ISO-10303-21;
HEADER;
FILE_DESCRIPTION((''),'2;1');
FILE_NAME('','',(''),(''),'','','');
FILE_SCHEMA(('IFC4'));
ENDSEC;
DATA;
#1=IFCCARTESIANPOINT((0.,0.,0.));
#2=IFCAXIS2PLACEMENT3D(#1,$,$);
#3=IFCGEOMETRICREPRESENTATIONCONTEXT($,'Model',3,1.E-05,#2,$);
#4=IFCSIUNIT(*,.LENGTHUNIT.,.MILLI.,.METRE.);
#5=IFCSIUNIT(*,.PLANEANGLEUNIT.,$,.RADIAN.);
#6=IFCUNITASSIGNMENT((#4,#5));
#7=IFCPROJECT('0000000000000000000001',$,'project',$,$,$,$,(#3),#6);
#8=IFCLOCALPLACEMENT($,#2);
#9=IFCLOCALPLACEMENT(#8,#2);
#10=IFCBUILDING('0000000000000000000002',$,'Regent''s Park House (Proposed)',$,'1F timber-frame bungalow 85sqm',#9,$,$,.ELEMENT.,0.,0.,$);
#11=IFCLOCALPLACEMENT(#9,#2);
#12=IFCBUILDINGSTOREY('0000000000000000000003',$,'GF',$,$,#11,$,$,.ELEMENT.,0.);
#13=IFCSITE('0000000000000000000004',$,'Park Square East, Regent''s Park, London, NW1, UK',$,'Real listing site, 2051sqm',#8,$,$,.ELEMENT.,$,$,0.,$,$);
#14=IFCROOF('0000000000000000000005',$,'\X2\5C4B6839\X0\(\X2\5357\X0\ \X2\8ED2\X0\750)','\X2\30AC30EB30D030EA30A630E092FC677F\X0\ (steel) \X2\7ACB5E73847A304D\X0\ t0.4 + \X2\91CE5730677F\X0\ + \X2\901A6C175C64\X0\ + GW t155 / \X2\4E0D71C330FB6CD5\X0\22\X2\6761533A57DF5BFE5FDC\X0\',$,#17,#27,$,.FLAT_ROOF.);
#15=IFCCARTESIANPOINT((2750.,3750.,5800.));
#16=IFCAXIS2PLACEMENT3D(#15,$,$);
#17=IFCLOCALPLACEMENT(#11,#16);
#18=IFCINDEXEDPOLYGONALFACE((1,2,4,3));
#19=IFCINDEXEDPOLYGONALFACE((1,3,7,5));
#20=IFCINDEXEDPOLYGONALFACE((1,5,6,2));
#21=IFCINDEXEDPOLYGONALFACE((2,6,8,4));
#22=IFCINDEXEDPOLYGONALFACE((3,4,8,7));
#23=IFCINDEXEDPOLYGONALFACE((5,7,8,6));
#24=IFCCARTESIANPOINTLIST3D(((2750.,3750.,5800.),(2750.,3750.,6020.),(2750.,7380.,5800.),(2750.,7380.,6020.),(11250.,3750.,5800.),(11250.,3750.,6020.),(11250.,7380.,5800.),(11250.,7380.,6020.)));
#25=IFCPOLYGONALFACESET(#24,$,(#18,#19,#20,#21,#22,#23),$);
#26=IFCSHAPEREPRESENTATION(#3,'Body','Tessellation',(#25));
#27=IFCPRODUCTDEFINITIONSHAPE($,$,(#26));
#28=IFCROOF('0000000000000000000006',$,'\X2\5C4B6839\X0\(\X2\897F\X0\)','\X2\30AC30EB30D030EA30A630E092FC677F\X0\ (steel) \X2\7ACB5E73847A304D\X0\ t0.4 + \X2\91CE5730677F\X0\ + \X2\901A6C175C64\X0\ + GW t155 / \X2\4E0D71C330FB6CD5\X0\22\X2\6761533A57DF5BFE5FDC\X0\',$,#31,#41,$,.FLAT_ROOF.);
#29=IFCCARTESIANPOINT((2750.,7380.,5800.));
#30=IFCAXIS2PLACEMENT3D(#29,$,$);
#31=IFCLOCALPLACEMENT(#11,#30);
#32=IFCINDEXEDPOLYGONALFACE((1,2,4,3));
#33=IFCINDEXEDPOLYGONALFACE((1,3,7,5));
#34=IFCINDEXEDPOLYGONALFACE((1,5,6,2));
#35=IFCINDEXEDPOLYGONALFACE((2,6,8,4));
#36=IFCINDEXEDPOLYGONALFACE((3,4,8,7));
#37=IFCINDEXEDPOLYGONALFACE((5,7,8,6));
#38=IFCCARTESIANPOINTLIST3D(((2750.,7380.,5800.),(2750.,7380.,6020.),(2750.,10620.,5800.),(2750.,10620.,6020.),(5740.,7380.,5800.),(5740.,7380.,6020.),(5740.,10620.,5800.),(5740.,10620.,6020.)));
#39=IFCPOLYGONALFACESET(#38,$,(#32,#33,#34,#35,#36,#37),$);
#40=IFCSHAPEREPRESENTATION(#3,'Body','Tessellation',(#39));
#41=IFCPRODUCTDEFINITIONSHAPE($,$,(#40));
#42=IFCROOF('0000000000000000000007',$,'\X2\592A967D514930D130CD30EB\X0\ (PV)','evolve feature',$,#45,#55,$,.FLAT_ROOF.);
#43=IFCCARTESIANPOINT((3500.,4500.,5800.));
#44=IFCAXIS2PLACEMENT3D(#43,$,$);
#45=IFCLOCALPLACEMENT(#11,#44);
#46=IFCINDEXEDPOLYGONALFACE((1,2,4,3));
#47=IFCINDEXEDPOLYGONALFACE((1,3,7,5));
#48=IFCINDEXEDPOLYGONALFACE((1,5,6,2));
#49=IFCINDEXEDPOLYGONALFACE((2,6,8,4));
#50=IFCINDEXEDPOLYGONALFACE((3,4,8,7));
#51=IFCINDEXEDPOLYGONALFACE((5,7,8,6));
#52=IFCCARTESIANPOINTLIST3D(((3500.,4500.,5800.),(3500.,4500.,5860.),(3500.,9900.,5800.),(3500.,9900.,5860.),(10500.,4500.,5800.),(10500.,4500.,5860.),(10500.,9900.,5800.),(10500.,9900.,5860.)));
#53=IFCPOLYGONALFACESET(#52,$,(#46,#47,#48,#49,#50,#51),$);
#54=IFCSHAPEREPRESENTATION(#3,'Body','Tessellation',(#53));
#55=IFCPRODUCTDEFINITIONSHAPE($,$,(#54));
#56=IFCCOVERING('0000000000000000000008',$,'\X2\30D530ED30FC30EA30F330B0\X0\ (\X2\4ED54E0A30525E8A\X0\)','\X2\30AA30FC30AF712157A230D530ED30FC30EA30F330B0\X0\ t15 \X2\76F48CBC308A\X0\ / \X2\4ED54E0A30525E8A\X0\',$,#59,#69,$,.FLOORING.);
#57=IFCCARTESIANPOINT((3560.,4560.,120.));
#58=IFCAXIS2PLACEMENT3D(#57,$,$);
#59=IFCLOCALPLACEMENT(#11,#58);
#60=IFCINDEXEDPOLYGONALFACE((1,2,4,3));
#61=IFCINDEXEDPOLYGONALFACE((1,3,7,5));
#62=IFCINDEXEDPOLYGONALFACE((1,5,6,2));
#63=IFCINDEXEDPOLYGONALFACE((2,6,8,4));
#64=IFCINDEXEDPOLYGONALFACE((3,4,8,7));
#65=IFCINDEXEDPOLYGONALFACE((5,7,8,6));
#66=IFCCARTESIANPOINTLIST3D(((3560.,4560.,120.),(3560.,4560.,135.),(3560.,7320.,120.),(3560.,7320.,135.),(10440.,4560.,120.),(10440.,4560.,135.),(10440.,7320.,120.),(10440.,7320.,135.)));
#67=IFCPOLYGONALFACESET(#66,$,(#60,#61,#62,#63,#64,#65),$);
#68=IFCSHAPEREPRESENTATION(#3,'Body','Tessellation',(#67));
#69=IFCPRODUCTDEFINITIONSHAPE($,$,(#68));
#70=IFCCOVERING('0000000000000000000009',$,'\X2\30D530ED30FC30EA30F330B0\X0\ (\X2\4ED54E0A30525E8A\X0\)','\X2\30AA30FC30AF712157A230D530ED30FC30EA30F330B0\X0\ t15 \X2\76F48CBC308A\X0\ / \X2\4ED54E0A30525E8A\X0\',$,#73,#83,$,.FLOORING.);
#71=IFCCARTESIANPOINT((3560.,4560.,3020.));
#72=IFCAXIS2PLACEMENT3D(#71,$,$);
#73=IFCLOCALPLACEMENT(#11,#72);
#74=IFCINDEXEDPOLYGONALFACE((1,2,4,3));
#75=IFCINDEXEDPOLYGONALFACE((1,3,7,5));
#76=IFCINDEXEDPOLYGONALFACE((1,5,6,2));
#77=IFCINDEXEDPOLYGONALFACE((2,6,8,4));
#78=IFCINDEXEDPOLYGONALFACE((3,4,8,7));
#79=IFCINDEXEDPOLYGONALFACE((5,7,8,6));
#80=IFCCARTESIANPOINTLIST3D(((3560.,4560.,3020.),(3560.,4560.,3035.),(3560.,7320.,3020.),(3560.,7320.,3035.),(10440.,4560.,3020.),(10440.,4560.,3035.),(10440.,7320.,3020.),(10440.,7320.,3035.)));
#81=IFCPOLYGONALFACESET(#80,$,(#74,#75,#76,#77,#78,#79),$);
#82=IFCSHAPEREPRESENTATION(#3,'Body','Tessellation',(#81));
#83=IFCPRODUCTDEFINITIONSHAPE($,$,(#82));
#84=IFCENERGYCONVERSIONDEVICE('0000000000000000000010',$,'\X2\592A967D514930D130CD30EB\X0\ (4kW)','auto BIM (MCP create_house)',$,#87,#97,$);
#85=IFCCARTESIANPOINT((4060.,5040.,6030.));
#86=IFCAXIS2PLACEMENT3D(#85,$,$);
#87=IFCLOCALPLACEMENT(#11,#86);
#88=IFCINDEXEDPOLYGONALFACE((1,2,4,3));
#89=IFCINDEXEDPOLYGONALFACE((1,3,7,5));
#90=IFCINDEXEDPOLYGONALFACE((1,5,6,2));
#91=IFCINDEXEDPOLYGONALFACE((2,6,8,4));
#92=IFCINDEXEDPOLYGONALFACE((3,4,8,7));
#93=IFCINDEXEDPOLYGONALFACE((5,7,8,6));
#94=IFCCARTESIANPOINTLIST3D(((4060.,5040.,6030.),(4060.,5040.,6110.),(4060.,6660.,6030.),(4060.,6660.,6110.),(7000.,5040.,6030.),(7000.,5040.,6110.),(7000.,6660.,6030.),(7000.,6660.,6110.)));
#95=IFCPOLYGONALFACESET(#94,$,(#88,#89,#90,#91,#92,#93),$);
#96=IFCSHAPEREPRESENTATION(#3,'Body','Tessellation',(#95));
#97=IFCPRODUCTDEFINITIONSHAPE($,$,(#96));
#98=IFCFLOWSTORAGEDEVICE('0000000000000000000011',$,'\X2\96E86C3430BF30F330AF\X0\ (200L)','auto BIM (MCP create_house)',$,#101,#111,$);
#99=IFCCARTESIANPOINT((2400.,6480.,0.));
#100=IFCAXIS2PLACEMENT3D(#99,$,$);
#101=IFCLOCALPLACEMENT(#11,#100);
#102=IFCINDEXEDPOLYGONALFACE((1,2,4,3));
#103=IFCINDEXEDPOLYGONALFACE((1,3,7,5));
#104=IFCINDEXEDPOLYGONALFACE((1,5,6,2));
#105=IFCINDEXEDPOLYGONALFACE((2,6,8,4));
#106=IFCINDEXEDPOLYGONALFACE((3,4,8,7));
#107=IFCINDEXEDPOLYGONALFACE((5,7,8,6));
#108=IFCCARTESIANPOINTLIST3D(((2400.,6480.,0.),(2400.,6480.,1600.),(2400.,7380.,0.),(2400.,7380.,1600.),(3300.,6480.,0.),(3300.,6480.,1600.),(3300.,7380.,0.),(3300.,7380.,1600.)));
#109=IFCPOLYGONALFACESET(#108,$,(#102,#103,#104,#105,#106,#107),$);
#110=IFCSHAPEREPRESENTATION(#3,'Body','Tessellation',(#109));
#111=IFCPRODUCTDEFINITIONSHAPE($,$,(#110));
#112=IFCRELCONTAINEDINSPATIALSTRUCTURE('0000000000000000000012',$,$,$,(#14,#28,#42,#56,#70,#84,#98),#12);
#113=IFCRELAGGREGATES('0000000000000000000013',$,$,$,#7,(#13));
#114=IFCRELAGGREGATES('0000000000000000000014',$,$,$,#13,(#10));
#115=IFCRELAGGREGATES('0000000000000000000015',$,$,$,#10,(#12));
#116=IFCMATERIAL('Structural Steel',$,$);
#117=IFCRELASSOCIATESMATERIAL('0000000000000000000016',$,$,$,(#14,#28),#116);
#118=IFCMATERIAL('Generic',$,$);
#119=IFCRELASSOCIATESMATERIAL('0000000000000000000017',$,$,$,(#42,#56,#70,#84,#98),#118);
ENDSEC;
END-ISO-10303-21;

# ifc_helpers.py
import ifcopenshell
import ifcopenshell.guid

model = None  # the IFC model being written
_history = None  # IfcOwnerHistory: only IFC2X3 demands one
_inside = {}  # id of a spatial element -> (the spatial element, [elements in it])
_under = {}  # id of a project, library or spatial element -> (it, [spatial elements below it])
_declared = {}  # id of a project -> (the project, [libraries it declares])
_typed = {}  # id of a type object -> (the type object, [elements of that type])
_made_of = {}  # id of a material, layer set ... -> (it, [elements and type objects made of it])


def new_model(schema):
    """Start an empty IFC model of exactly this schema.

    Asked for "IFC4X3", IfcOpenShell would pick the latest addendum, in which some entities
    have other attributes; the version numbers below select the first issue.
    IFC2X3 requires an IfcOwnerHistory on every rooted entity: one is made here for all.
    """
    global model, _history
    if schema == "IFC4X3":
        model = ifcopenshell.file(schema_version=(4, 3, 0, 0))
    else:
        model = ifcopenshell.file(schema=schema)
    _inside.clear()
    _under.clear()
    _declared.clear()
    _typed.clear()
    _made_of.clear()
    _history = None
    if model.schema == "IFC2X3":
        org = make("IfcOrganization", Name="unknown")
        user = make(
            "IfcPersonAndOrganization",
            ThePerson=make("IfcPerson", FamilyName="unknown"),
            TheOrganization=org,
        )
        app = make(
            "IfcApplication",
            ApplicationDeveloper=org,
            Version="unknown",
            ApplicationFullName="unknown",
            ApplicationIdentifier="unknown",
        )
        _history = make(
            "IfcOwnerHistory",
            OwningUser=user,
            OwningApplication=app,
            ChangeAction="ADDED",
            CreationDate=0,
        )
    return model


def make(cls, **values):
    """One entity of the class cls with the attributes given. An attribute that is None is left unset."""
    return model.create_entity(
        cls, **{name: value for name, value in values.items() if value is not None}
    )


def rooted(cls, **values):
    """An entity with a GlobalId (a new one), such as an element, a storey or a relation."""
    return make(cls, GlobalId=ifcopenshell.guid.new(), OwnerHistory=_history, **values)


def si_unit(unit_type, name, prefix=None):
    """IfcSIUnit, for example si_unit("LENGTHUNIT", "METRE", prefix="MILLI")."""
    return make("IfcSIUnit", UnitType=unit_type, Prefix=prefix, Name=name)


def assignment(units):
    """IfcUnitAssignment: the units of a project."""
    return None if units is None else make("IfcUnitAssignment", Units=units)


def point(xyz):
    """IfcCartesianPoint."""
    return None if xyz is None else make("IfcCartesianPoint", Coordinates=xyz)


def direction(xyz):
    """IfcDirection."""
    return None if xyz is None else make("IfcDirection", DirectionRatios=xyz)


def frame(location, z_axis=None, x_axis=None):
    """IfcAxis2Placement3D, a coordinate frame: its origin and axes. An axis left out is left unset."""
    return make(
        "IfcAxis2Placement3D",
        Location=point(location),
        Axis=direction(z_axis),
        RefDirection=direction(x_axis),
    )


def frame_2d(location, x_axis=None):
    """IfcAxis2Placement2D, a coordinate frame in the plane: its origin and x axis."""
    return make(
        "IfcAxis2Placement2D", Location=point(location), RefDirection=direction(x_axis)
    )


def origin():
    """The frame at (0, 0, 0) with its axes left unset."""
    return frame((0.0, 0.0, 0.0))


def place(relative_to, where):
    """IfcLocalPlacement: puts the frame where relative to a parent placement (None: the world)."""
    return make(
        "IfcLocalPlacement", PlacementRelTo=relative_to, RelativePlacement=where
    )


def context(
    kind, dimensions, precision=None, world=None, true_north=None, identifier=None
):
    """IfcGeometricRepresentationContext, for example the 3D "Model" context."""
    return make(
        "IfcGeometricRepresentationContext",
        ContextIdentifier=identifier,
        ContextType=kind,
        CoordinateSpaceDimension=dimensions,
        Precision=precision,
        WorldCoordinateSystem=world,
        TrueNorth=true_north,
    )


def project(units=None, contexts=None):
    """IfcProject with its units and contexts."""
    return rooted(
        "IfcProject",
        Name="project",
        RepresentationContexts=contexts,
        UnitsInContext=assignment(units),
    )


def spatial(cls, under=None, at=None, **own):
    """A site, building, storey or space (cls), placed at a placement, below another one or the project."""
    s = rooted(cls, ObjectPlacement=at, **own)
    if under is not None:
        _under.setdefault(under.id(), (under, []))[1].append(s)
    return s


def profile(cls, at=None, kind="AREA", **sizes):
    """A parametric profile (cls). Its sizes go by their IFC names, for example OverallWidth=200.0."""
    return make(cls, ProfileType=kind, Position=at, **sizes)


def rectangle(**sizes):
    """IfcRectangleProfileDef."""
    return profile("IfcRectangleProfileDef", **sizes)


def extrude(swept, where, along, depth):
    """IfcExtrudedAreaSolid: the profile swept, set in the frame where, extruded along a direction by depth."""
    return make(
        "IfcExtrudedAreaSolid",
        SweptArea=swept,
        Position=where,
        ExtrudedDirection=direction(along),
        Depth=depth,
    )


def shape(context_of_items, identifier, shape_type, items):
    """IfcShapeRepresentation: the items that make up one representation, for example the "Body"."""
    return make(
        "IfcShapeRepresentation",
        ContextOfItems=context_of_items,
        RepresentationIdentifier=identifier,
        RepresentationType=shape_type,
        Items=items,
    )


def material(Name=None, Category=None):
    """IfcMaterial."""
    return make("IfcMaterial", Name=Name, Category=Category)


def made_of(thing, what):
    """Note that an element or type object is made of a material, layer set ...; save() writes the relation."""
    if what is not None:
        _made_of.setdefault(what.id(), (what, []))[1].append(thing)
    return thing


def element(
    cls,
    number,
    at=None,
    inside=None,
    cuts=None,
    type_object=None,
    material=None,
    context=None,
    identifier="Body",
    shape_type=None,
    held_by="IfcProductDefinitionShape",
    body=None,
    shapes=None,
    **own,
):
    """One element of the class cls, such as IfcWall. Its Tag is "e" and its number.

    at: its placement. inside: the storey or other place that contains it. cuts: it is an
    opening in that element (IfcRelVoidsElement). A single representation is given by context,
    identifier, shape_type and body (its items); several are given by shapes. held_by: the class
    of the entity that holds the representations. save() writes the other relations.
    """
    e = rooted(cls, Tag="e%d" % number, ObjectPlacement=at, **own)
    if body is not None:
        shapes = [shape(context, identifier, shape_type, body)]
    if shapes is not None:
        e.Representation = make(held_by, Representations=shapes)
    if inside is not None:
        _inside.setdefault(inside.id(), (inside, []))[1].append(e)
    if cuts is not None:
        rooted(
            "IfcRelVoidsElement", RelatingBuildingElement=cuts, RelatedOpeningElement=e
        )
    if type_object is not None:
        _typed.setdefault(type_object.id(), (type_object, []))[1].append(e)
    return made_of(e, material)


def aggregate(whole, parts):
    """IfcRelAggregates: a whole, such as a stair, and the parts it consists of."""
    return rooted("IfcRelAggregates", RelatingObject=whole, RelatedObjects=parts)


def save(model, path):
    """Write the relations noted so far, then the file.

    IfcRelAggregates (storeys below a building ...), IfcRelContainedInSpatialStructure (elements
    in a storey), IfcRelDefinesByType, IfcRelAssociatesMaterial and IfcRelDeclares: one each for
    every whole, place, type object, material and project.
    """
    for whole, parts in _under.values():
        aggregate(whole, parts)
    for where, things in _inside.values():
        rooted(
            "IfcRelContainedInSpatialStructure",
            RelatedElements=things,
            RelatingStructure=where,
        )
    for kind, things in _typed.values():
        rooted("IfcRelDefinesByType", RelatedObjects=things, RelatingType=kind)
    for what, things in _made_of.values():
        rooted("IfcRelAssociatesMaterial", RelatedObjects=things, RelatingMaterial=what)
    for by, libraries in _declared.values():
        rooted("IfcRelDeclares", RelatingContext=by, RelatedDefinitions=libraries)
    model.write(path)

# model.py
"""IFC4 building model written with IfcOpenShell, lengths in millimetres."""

from ifc_helpers import new_model, si_unit, frame, frame_2d, origin, place, context, project, spatial, rectangle, extrude, material, element, save


model = new_model("IFC4")

# Units and contexts
model_context = context("Model", 3, precision=1e-05, world=origin())
ifc_project = project(units=[si_unit("LENGTHUNIT", "METRE", prefix="MILLI"), si_unit("PLANEANGLEUNIT", "RADIAN")], contexts=[model_context])

# Site, building, storey
site_placement = place(None, origin())
site = spatial("IfcSite", under=ifc_project, at=site_placement, Name="Park Square East, Regent's Park, London, NW1, UK", ObjectType="Real listing site, 2051sqm", CompositionType="ELEMENT", RefElevation=0.0)
building_placement = place(site_placement, origin())
building = spatial("IfcBuilding", under=site, at=building_placement, Name="Regent's Park House (Proposed)", ObjectType="1F timber-frame bungalow 85sqm", CompositionType="ELEMENT", ElevationOfRefHeight=0.0, ElevationOfTerrain=0.0)
storey_placement = place(building_placement, origin())
storey = spatial("IfcBuildingStorey", under=building, at=storey_placement, Name="GF", CompositionType="ELEMENT", Elevation=0.0)

# Shared definitions
ifc_material_1 = material(Name="Generic")

# Roofs
ifc_material_2 = material(Name="Structural Steel")
roof_1_placement = place(storey_placement, frame((2750.0, 3750.0, 5800.0)))
element("IfcRoof", 1, at=roof_1_placement, inside=storey, material=ifc_material_2, Name="屋根(南 軒750)", Description="ガルバリウム鋼板 (steel) 立平葺き t0.4 + 野地板 + 通気層 + GW t155 / 不燃・法22条区域対応", PredefinedType="FLAT_ROOF", context=model_context, shape_type="SweptSolid", body=[
    extrude(rectangle(XDim=8500.0, YDim=3630.0, at=frame_2d((4250.0, 1815.0))), frame((2750.0, 3750.0, 5800.0)), (0.0, 0.0, 1.0), 220.0),
])
roof_2_placement = place(storey_placement, frame((2750.0, 7380.0, 5800.0)))
element("IfcRoof", 2, at=roof_2_placement, inside=storey, material=ifc_material_2, Name="屋根(西)", Description="ガルバリウム鋼板 (steel) 立平葺き t0.4 + 野地板 + 通気層 + GW t155 / 不燃・法22条区域対応", PredefinedType="FLAT_ROOF", context=model_context, shape_type="SweptSolid", body=[
    extrude(rectangle(XDim=2990.0, YDim=3240.0, at=frame_2d((1495.0, 1620.0))), frame((2750.0, 7380.0, 5800.0)), (0.0, 0.0, 1.0), 220.0),
])
roof_3_placement = place(storey_placement, frame((3500.0, 4500.0, 5800.0)))
element("IfcRoof", 3, at=roof_3_placement, inside=storey, material=ifc_material_1, Name="太陽光パネル (PV)", Description="evolve feature", PredefinedType="FLAT_ROOF", context=model_context, shape_type="SweptSolid", body=[
    extrude(rectangle(XDim=7000.0, YDim=5400.0, at=frame_2d((3500.0, 2700.0))), frame((3500.0, 4500.0, 5800.0)), (0.0, 0.0, 1.0), 60.0),
])

# Coverings
covering_1_placement = place(storey_placement, frame((3560.0, 4560.0, 120.0)))
element("IfcCovering", 4, at=covering_1_placement, inside=storey, material=ifc_material_1, Name="フローリング (仕上げ床)", Description="オーク無垢フローリング t15 直貼り / 仕上げ床", PredefinedType="FLOORING", context=model_context, shape_type="SweptSolid", body=[
    extrude(rectangle(XDim=6880.0, YDim=2760.0, at=frame_2d((3440.0, 1380.0))), frame((3560.0, 4560.0, 120.0)), (0.0, 0.0, 1.0), 15.0),
])
covering_2_placement = place(storey_placement, frame((3560.0, 4560.0, 3020.0)))
element("IfcCovering", 5, at=covering_2_placement, inside=storey, material=ifc_material_1, Name="フローリング (仕上げ床)", Description="オーク無垢フローリング t15 直貼り / 仕上げ床", PredefinedType="FLOORING", context=model_context, shape_type="SweptSolid", body=[
    extrude(rectangle(XDim=6880.0, YDim=2760.0, at=frame_2d((3440.0, 1380.0))), frame((3560.0, 4560.0, 3020.0)), (0.0, 0.0, 1.0), 15.0),
])

# Energy conversion device
energy_conversion_device_placement = place(storey_placement, frame((4060.0, 5040.0, 6030.0)))
element("IfcEnergyConversionDevice", 6, at=energy_conversion_device_placement, inside=storey, material=ifc_material_1, Name="太陽光パネル (4kW)", Description="auto BIM (MCP create_house)", context=model_context, shape_type="SweptSolid", body=[
    extrude(rectangle(XDim=2940.0, YDim=1620.0, at=frame_2d((1470.0, 810.0))), frame((4060.0, 5040.0, 6030.0)), (0.0, 0.0, 1.0), 80.0),
])

# Flow storage device
flow_storage_device_placement = place(storey_placement, frame((2400.0, 6480.0, 0.0)))
element("IfcFlowStorageDevice", 7, at=flow_storage_device_placement, inside=storey, material=ifc_material_1, Name="雨水タンク (200L)", Description="auto BIM (MCP create_house)", context=model_context, shape_type="SweptSolid", body=[
    extrude(rectangle(XDim=900.0, YDim=900.0, at=frame_2d((450.0, 450.0))), frame((2400.0, 6480.0, 0.0)), (0.0, 0.0, 1.0), 1600.0),
])

save(model, "model.ifc")
